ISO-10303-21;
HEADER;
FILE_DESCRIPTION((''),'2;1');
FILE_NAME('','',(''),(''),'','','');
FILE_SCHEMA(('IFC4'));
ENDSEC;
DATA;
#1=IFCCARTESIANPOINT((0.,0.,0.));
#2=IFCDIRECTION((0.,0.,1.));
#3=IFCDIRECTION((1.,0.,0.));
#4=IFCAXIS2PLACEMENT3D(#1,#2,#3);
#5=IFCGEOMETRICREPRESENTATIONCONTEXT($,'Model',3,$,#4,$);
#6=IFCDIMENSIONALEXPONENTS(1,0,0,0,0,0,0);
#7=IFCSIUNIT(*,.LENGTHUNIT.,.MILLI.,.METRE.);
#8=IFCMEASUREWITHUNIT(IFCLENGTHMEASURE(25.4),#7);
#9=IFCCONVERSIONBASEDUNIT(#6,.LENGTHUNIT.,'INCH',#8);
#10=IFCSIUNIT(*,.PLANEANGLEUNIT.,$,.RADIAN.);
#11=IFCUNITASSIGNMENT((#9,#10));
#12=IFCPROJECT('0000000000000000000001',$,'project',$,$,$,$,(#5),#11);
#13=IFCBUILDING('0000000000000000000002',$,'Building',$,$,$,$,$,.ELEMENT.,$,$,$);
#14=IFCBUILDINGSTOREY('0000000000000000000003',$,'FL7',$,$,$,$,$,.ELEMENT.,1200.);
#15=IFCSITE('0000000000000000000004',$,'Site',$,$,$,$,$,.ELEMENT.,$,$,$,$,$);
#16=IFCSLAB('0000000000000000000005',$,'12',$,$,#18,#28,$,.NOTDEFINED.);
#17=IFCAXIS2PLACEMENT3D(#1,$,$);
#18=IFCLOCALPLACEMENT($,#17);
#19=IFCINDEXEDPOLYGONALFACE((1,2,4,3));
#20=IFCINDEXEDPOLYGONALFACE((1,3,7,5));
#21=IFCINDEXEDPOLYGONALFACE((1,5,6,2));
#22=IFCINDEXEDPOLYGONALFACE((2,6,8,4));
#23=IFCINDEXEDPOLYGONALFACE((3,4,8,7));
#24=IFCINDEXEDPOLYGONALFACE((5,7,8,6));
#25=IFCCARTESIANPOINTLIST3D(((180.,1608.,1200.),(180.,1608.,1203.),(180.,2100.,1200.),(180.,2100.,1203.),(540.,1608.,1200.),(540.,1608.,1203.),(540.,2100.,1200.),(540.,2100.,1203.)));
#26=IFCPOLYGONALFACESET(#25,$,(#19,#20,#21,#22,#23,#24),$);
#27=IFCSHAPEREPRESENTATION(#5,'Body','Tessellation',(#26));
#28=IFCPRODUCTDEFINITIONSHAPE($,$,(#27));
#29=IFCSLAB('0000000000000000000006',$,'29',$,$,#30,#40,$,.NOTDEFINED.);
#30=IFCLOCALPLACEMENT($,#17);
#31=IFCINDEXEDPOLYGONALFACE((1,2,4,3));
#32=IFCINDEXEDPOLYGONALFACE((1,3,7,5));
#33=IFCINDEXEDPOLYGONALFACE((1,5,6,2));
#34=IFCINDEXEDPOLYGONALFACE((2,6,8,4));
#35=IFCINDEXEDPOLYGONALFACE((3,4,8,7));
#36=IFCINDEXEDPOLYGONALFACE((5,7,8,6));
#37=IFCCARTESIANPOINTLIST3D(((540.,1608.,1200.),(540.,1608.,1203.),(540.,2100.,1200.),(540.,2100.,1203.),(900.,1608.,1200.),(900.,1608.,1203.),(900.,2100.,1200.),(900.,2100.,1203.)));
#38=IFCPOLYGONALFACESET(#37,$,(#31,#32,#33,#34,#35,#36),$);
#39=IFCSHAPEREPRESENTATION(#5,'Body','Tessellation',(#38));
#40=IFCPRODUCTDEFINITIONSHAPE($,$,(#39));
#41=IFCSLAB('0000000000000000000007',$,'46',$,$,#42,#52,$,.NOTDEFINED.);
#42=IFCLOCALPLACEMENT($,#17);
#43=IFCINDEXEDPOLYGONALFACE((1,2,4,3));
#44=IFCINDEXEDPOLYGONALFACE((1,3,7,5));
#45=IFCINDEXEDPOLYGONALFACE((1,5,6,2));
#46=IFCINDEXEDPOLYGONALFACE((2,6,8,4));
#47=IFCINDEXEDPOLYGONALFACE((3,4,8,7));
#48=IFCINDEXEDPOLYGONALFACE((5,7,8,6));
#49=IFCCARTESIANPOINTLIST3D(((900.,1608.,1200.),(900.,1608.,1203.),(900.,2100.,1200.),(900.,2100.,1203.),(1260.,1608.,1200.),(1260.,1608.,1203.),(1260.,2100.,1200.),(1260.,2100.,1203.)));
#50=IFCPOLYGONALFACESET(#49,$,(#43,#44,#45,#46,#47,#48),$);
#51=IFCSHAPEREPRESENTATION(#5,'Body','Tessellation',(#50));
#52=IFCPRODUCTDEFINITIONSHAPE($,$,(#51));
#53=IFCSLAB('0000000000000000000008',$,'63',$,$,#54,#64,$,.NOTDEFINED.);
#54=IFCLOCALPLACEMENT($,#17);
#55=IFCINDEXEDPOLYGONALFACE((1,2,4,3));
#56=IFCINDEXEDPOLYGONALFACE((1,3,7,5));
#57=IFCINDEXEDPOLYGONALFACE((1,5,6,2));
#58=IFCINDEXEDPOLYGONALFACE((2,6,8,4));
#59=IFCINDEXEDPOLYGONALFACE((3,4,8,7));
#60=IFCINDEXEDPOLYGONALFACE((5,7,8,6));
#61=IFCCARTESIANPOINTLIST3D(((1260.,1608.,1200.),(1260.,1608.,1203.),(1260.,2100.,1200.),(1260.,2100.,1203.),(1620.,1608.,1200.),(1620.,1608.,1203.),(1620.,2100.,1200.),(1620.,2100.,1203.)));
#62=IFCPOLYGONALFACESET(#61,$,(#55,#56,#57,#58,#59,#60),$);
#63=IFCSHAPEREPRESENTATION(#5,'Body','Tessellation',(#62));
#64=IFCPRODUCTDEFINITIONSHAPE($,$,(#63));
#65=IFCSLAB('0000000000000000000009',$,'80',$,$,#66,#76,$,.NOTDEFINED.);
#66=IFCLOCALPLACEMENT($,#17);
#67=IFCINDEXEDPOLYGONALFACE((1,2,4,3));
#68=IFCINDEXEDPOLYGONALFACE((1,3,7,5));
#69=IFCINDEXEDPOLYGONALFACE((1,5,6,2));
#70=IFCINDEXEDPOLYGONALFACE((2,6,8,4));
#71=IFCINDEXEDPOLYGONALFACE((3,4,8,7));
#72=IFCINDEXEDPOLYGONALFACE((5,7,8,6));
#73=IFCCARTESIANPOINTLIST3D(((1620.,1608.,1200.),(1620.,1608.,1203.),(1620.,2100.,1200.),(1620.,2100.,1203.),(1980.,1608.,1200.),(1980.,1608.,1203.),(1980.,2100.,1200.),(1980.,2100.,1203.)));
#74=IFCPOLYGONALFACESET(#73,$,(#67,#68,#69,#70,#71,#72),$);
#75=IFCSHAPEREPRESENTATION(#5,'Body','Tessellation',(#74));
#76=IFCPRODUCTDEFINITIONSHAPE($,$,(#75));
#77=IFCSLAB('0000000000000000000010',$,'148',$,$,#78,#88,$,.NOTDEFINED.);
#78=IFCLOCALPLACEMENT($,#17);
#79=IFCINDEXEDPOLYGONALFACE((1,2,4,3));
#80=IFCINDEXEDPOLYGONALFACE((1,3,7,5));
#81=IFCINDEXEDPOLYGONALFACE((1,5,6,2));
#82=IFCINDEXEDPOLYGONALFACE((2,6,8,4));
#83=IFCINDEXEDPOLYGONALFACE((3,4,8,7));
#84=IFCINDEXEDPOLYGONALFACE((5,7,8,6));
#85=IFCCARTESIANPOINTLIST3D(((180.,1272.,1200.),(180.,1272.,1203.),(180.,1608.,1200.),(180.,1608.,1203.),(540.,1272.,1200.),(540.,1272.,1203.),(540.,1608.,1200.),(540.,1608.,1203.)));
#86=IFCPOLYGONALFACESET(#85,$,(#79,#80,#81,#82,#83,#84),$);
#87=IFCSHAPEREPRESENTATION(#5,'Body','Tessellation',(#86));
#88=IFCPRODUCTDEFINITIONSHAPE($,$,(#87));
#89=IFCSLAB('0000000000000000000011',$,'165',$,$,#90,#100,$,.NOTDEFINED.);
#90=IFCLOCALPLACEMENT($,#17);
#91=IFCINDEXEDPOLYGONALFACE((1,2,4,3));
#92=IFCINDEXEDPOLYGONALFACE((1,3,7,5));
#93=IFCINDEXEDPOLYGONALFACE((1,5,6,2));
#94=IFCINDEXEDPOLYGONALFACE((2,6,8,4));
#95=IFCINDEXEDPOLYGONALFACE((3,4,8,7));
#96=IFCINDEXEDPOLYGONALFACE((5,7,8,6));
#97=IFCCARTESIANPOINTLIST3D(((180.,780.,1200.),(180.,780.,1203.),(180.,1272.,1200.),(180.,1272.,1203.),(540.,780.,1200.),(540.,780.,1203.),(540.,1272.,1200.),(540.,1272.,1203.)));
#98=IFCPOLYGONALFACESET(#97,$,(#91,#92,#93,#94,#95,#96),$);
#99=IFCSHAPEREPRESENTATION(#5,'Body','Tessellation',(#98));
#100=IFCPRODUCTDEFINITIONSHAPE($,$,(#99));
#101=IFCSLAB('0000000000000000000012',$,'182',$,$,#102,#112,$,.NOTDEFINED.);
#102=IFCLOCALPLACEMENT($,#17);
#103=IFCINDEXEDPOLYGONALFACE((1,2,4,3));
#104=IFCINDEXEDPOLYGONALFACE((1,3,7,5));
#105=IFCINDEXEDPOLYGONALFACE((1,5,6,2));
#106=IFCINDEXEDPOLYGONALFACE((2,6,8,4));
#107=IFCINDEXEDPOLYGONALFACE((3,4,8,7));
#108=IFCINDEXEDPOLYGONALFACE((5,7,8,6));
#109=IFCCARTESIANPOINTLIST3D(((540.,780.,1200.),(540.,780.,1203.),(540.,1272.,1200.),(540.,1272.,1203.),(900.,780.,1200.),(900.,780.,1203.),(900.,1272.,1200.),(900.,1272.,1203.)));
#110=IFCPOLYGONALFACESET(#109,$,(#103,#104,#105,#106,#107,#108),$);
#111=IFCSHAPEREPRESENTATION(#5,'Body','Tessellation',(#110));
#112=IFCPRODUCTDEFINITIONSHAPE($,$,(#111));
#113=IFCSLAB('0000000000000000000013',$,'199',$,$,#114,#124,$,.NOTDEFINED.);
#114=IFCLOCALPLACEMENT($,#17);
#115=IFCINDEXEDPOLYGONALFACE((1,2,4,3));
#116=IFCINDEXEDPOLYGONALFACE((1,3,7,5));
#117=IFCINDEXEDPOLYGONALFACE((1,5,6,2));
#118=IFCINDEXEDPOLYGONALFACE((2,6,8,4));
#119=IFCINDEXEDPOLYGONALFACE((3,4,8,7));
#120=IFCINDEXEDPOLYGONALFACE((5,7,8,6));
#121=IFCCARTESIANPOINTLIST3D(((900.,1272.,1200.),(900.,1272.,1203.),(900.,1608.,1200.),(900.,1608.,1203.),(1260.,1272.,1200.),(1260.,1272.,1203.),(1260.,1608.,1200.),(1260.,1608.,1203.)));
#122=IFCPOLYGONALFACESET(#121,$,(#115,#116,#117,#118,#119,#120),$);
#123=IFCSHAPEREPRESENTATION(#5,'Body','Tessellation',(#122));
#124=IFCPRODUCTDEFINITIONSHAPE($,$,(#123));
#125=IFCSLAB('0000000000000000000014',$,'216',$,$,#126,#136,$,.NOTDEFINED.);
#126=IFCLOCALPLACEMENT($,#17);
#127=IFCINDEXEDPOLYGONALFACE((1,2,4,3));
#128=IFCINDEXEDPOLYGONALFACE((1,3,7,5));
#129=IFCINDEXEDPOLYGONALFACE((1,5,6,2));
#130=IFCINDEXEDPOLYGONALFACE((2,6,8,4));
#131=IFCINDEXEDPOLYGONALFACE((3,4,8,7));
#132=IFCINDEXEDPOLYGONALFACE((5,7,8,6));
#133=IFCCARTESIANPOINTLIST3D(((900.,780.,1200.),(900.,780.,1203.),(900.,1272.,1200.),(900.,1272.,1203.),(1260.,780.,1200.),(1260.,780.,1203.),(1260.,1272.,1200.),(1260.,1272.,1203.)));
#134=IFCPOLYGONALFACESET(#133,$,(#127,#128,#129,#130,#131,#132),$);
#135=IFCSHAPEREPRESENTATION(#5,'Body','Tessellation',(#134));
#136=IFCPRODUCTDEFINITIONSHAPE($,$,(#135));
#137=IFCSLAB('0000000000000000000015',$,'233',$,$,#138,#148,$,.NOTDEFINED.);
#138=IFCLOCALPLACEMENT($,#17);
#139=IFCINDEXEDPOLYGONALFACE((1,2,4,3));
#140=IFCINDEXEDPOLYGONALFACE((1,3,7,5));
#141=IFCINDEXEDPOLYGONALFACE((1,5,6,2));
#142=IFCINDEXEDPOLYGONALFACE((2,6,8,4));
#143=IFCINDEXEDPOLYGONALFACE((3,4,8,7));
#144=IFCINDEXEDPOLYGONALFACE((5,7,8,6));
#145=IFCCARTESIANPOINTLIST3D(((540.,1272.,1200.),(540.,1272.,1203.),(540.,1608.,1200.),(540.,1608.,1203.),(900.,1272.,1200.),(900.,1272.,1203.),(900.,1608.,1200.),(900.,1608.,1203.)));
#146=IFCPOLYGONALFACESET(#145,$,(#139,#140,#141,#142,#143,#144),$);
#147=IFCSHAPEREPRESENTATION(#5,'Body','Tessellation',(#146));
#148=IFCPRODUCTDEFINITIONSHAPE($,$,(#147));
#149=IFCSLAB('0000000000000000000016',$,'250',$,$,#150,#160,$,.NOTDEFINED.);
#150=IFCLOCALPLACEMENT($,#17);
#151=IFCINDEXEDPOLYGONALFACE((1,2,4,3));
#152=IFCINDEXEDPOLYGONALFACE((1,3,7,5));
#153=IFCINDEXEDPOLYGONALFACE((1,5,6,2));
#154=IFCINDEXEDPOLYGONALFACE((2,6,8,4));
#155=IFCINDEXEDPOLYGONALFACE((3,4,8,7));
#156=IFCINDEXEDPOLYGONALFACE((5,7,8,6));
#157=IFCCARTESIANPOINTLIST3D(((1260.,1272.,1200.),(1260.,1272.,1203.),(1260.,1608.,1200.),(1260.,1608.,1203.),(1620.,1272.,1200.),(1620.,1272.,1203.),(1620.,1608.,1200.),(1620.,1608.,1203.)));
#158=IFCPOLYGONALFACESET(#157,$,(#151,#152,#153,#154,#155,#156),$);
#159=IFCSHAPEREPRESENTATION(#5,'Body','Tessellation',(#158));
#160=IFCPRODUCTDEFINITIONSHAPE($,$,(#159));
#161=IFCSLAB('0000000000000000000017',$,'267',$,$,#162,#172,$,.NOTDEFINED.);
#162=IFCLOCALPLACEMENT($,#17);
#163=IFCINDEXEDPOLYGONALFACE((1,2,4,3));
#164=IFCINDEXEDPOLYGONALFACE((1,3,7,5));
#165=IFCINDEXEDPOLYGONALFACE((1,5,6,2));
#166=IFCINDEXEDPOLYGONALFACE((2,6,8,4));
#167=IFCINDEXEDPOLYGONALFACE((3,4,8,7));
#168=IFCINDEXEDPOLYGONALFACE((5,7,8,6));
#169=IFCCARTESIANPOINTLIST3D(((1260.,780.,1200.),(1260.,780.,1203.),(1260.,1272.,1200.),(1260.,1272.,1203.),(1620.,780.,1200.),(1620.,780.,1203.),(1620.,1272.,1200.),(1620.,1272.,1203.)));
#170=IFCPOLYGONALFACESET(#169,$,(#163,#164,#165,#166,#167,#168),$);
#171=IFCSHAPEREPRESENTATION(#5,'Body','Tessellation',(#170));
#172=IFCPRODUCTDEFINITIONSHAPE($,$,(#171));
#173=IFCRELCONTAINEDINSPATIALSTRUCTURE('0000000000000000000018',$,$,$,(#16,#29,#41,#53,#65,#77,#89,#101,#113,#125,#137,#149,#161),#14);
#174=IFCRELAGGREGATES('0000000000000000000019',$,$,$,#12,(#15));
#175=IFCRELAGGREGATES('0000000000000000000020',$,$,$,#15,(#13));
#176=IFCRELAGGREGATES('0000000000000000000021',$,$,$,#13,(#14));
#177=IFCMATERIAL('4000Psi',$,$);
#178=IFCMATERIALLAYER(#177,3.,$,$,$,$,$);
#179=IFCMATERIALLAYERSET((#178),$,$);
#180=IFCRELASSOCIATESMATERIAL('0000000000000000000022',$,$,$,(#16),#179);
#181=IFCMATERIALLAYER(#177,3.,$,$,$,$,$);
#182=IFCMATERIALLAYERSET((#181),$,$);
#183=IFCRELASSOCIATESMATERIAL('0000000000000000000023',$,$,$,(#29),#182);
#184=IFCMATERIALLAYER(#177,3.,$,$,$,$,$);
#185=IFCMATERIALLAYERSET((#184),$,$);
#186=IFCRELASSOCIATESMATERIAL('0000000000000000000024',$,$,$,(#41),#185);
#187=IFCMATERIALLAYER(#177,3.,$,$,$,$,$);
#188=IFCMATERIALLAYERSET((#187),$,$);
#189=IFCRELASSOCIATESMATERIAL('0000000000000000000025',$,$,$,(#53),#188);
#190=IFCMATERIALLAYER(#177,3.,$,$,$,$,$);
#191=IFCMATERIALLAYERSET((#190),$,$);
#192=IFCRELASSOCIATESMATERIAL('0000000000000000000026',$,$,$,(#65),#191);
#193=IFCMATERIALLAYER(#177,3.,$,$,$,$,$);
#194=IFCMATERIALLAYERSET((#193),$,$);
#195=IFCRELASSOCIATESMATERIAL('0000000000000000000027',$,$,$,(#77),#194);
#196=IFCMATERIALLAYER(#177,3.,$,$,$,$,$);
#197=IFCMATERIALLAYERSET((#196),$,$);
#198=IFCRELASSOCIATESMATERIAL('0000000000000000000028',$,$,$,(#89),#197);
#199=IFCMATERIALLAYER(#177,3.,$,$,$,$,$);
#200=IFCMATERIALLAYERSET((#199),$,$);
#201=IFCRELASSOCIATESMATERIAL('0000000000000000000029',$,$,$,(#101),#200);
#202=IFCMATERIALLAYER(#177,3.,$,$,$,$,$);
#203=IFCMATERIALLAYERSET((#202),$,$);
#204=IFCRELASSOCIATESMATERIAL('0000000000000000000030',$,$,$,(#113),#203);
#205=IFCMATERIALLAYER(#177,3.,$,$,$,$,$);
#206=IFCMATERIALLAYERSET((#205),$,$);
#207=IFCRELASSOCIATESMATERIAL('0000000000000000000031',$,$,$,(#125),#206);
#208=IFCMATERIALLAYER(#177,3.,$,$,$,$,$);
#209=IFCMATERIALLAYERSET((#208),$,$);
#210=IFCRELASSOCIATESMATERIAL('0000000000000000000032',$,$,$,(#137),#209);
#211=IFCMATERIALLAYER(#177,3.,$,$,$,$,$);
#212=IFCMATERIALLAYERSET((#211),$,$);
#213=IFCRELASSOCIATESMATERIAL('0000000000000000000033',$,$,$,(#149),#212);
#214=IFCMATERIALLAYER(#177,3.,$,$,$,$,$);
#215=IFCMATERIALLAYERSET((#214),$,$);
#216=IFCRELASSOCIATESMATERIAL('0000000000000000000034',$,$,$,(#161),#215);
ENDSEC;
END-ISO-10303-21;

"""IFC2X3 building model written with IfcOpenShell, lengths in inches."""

from ifc_helpers import new_model, entity, si_unit, converted_unit, frame, origin_with_axes, place, context, project, spatial, polyline, outline, extrude, material, layer, layer_set, layer_usage, element, save


model = new_model("IFC2X3")

# Units and contexts
model_context = context("Model", 3, world=origin_with_axes())
ifc_project = project(units=[converted_unit("LENGTHUNIT", "INCH", entity("IfcLengthMeasure", 25.4), si_unit("LENGTHUNIT", "METRE", prefix="MILLI"), dimensions=[1, 0, 0, 0, 0, 0, 0]), si_unit("PLANEANGLEUNIT", "RADIAN")], contexts=[model_context])

# Site, building, storey
site = spatial("IfcSite", under=ifc_project, Name="Site", CompositionType="ELEMENT")
building = spatial("IfcBuilding", under=site, Name="Building", CompositionType="ELEMENT")
storey = spatial("IfcBuildingStorey", under=building, Name="FL7", CompositionType="ELEMENT", Elevation=1200.0)

# Slabs
ifc_material_1 = material(Name="4000Psi")
ifc_layer_1 = layer(ifc_material_1, 3.0)
ifc_layer_set_1 = layer_set([ifc_layer_1])
ifc_layer_usage_1 = layer_usage(ifc_layer_set_1, "AXIS2", "POSITIVE", -3.0)
slab_1_placement = place(None, frame((180.0, 1608.0, 1200.0), z_axis=(0.0, 0.0, 1.0), x_axis=(1.0, 0.0, 0.0)))
element("IfcSlab", 1, at=slab_1_placement, inside=storey, material=ifc_layer_usage_1, Name="12", PredefinedType="NOTDEFINED", context=model_context, shape_type="SweptSolid", body=[
    extrude(outline(polyline([(0.0, 0.0), (360.0, 0.0), (360.0, 492.0), (0.0, 492.0), (0.0, 0.0)])), origin_with_axes(), (0.0, 0.0, 1.0), 3.0),
])
ifc_layer_2 = layer(ifc_material_1, 3.0)
ifc_layer_set_2 = layer_set([ifc_layer_2])
ifc_layer_usage_2 = layer_usage(ifc_layer_set_2, "AXIS2", "POSITIVE", -3.0)
slab_2_placement = place(None, frame((540.0, 1608.0, 1200.0), z_axis=(0.0, 0.0, 1.0), x_axis=(1.0, 0.0, 0.0)))
element("IfcSlab", 2, at=slab_2_placement, inside=storey, material=ifc_layer_usage_2, Name="29", PredefinedType="NOTDEFINED", context=model_context, shape_type="SweptSolid", body=[
    extrude(outline(polyline([(0.0, 0.0), (360.0, 0.0), (360.0, 492.0), (0.0, 492.0), (0.0, 0.0)])), origin_with_axes(), (0.0, 0.0, 1.0), 3.0),
])
ifc_layer_3 = layer(ifc_material_1, 3.0)
ifc_layer_set_3 = layer_set([ifc_layer_3])
ifc_layer_usage_3 = layer_usage(ifc_layer_set_3, "AXIS2", "POSITIVE", -3.0)
slab_3_placement = place(None, frame((900.0, 1608.0, 1200.0), z_axis=(0.0, 0.0, 1.0), x_axis=(1.0, 0.0, 0.0)))
element("IfcSlab", 3, at=slab_3_placement, inside=storey, material=ifc_layer_usage_3, Name="46", PredefinedType="NOTDEFINED", context=model_context, shape_type="SweptSolid", body=[
    extrude(outline(polyline([(0.0, 0.0), (360.0, 0.0), (360.0, 492.0), (0.0, 492.0), (0.0, 0.0)])), origin_with_axes(), (0.0, 0.0, 1.0), 3.0),
])
ifc_layer_4 = layer(ifc_material_1, 3.0)
ifc_layer_set_4 = layer_set([ifc_layer_4])
ifc_layer_usage_4 = layer_usage(ifc_layer_set_4, "AXIS2", "POSITIVE", -3.0)
slab_4_placement = place(None, frame((1260.0, 1608.0, 1200.0), z_axis=(0.0, 0.0, 1.0), x_axis=(1.0, 0.0, 0.0)))
element("IfcSlab", 4, at=slab_4_placement, inside=storey, material=ifc_layer_usage_4, Name="63", PredefinedType="NOTDEFINED", context=model_context, shape_type="SweptSolid", body=[
    extrude(outline(polyline([(0.0, 0.0), (360.0, 0.0), (360.0, 492.0), (0.0, 492.0), (0.0, 0.0)])), origin_with_axes(), (0.0, 0.0, 1.0), 3.0),
])
ifc_layer_5 = layer(ifc_material_1, 3.0)
ifc_layer_set_5 = layer_set([ifc_layer_5])
ifc_layer_usage_5 = layer_usage(ifc_layer_set_5, "AXIS2", "POSITIVE", -3.0)
slab_5_placement = place(None, frame((1620.0, 1608.0, 1200.0), z_axis=(0.0, 0.0, 1.0), x_axis=(1.0, 0.0, 0.0)))
element("IfcSlab", 5, at=slab_5_placement, inside=storey, material=ifc_layer_usage_5, Name="80", PredefinedType="NOTDEFINED", context=model_context, shape_type="SweptSolid", body=[
    extrude(outline(polyline([(0.0, 0.0), (360.0, 0.0), (360.0, 492.0), (0.0, 492.0), (0.0, 0.0)])), origin_with_axes(), (0.0, 0.0, 1.0), 3.0),
])
ifc_layer_6 = layer(ifc_material_1, 3.0)
ifc_layer_set_6 = layer_set([ifc_layer_6])
ifc_layer_usage_6 = layer_usage(ifc_layer_set_6, "AXIS2", "POSITIVE", -3.0)
slab_6_placement = place(None, frame((180.0, 1272.0, 1200.0), z_axis=(0.0, 0.0, 1.0), x_axis=(1.0, 0.0, 0.0)))
element("IfcSlab", 6, at=slab_6_placement, inside=storey, material=ifc_layer_usage_6, Name="148", PredefinedType="NOTDEFINED", context=model_context, shape_type="SweptSolid", body=[
    extrude(outline(polyline([(0.0, 0.0), (360.0, 0.0), (360.0, 336.0), (0.0, 336.0), (0.0, 0.0)])), origin_with_axes(), (0.0, 0.0, 1.0), 3.0),
])
ifc_layer_7 = layer(ifc_material_1, 3.0)
ifc_layer_set_7 = layer_set([ifc_layer_7])
ifc_layer_usage_7 = layer_usage(ifc_layer_set_7, "AXIS2", "POSITIVE", -3.0)
slab_7_placement = place(None, frame((180.0, 780.0, 1200.0), z_axis=(0.0, 0.0, 1.0), x_axis=(1.0, 0.0, 0.0)))
element("IfcSlab", 7, at=slab_7_placement, inside=storey, material=ifc_layer_usage_7, Name="165", PredefinedType="NOTDEFINED", context=model_context, shape_type="SweptSolid", body=[
    extrude(outline(polyline([(0.0, 0.0), (360.0, 0.0), (360.0, 492.0), (0.0, 492.0), (0.0, 0.0)])), origin_with_axes(), (0.0, 0.0, 1.0), 3.0),
])
ifc_layer_8 = layer(ifc_material_1, 3.0)
ifc_layer_set_8 = layer_set([ifc_layer_8])
ifc_layer_usage_8 = layer_usage(ifc_layer_set_8, "AXIS2", "POSITIVE", -3.0)
slab_8_placement = place(None, frame((540.0, 780.0, 1200.0), z_axis=(0.0, 0.0, 1.0), x_axis=(1.0, 0.0, 0.0)))
element("IfcSlab", 8, at=slab_8_placement, inside=storey, material=ifc_layer_usage_8, Name="182", PredefinedType="NOTDEFINED", context=model_context, shape_type="SweptSolid", body=[
    extrude(outline(polyline([(0.0, 0.0), (360.0, 0.0), (360.0, 492.0), (0.0, 492.0), (0.0, 0.0)])), origin_with_axes(), (0.0, 0.0, 1.0), 3.0),
])
ifc_layer_9 = layer(ifc_material_1, 3.0)
ifc_layer_set_9 = layer_set([ifc_layer_9])
ifc_layer_usage_9 = layer_usage(ifc_layer_set_9, "AXIS2", "POSITIVE", -3.0)
slab_9_placement = place(None, frame((900.0, 1272.0, 1200.0), z_axis=(0.0, 0.0, 1.0), x_axis=(1.0, 0.0, 0.0)))
element("IfcSlab", 9, at=slab_9_placement, inside=storey, material=ifc_layer_usage_9, Name="199", PredefinedType="NOTDEFINED", context=model_context, shape_type="SweptSolid", body=[
    extrude(outline(polyline([(0.0, 0.0), (360.0, 0.0), (360.0, 336.0), (0.0, 336.0), (0.0, 0.0)])), origin_with_axes(), (0.0, 0.0, 1.0), 3.0),
])
ifc_layer_10 = layer(ifc_material_1, 3.0)
ifc_layer_set_10 = layer_set([ifc_layer_10])
ifc_layer_usage_10 = layer_usage(ifc_layer_set_10, "AXIS2", "POSITIVE", -3.0)
slab_10_placement = place(None, frame((900.0, 780.0, 1200.0), z_axis=(0.0, 0.0, 1.0), x_axis=(1.0, 0.0, 0.0)))
element("IfcSlab", 10, at=slab_10_placement, inside=storey, material=ifc_layer_usage_10, Name="216", PredefinedType="NOTDEFINED", context=model_context, shape_type="SweptSolid", body=[
    extrude(outline(polyline([(0.0, 0.0), (360.0, 0.0), (360.0, 492.0), (0.0, 492.0), (0.0, 0.0)])), origin_with_axes(), (0.0, 0.0, 1.0), 3.0),
])
ifc_layer_11 = layer(ifc_material_1, 3.0)
ifc_layer_set_11 = layer_set([ifc_layer_11])
ifc_layer_usage_11 = layer_usage(ifc_layer_set_11, "AXIS2", "POSITIVE", -3.0)
slab_11_placement = place(None, frame((540.0, 1272.0, 1200.0), z_axis=(0.0, 0.0, 1.0), x_axis=(1.0, 0.0, 0.0)))
element("IfcSlab", 11, at=slab_11_placement, inside=storey, material=ifc_layer_usage_11, Name="233", PredefinedType="NOTDEFINED", context=model_context, shape_type="SweptSolid", body=[
    extrude(outline(polyline([(0.0, 0.0), (360.0, 0.0), (360.0, 336.0), (0.0, 336.0), (0.0, 0.0)])), origin_with_axes(), (0.0, 0.0, 1.0), 3.0),
])
ifc_layer_12 = layer(ifc_material_1, 3.0)
ifc_layer_set_12 = layer_set([ifc_layer_12])
ifc_layer_usage_12 = layer_usage(ifc_layer_set_12, "AXIS2", "POSITIVE", -3.0)
slab_12_placement = place(None, frame((1260.0, 1272.0, 1200.0), z_axis=(0.0, 0.0, 1.0), x_axis=(1.0, 0.0, 0.0)))
element("IfcSlab", 12, at=slab_12_placement, inside=storey, material=ifc_layer_usage_12, Name="250", PredefinedType="NOTDEFINED", context=model_context, shape_type="SweptSolid", body=[
    extrude(outline(polyline([(0.0, 0.0), (360.0, 0.0), (360.0, 336.0), (0.0, 336.0), (0.0, 0.0)])), origin_with_axes(), (0.0, 0.0, 1.0), 3.0),
])
ifc_layer_13 = layer(ifc_material_1, 3.0)
ifc_layer_set_13 = layer_set([ifc_layer_13])
ifc_layer_usage_13 = layer_usage(ifc_layer_set_13, "AXIS2", "POSITIVE", -3.0)
slab_13_placement = place(None, frame((1260.0, 780.0, 1200.0), z_axis=(0.0, 0.0, 1.0), x_axis=(1.0, 0.0, 0.0)))
element("IfcSlab", 13, at=slab_13_placement, inside=storey, material=ifc_layer_usage_13, Name="267", PredefinedType="NOTDEFINED", context=model_context, shape_type="SweptSolid", body=[
    extrude(outline(polyline([(0.0, 0.0), (360.0, 0.0), (360.0, 492.0), (0.0, 492.0), (0.0, 0.0)])), origin_with_axes(), (0.0, 0.0, 1.0), 3.0),
])

save(model, "model.ifc")
